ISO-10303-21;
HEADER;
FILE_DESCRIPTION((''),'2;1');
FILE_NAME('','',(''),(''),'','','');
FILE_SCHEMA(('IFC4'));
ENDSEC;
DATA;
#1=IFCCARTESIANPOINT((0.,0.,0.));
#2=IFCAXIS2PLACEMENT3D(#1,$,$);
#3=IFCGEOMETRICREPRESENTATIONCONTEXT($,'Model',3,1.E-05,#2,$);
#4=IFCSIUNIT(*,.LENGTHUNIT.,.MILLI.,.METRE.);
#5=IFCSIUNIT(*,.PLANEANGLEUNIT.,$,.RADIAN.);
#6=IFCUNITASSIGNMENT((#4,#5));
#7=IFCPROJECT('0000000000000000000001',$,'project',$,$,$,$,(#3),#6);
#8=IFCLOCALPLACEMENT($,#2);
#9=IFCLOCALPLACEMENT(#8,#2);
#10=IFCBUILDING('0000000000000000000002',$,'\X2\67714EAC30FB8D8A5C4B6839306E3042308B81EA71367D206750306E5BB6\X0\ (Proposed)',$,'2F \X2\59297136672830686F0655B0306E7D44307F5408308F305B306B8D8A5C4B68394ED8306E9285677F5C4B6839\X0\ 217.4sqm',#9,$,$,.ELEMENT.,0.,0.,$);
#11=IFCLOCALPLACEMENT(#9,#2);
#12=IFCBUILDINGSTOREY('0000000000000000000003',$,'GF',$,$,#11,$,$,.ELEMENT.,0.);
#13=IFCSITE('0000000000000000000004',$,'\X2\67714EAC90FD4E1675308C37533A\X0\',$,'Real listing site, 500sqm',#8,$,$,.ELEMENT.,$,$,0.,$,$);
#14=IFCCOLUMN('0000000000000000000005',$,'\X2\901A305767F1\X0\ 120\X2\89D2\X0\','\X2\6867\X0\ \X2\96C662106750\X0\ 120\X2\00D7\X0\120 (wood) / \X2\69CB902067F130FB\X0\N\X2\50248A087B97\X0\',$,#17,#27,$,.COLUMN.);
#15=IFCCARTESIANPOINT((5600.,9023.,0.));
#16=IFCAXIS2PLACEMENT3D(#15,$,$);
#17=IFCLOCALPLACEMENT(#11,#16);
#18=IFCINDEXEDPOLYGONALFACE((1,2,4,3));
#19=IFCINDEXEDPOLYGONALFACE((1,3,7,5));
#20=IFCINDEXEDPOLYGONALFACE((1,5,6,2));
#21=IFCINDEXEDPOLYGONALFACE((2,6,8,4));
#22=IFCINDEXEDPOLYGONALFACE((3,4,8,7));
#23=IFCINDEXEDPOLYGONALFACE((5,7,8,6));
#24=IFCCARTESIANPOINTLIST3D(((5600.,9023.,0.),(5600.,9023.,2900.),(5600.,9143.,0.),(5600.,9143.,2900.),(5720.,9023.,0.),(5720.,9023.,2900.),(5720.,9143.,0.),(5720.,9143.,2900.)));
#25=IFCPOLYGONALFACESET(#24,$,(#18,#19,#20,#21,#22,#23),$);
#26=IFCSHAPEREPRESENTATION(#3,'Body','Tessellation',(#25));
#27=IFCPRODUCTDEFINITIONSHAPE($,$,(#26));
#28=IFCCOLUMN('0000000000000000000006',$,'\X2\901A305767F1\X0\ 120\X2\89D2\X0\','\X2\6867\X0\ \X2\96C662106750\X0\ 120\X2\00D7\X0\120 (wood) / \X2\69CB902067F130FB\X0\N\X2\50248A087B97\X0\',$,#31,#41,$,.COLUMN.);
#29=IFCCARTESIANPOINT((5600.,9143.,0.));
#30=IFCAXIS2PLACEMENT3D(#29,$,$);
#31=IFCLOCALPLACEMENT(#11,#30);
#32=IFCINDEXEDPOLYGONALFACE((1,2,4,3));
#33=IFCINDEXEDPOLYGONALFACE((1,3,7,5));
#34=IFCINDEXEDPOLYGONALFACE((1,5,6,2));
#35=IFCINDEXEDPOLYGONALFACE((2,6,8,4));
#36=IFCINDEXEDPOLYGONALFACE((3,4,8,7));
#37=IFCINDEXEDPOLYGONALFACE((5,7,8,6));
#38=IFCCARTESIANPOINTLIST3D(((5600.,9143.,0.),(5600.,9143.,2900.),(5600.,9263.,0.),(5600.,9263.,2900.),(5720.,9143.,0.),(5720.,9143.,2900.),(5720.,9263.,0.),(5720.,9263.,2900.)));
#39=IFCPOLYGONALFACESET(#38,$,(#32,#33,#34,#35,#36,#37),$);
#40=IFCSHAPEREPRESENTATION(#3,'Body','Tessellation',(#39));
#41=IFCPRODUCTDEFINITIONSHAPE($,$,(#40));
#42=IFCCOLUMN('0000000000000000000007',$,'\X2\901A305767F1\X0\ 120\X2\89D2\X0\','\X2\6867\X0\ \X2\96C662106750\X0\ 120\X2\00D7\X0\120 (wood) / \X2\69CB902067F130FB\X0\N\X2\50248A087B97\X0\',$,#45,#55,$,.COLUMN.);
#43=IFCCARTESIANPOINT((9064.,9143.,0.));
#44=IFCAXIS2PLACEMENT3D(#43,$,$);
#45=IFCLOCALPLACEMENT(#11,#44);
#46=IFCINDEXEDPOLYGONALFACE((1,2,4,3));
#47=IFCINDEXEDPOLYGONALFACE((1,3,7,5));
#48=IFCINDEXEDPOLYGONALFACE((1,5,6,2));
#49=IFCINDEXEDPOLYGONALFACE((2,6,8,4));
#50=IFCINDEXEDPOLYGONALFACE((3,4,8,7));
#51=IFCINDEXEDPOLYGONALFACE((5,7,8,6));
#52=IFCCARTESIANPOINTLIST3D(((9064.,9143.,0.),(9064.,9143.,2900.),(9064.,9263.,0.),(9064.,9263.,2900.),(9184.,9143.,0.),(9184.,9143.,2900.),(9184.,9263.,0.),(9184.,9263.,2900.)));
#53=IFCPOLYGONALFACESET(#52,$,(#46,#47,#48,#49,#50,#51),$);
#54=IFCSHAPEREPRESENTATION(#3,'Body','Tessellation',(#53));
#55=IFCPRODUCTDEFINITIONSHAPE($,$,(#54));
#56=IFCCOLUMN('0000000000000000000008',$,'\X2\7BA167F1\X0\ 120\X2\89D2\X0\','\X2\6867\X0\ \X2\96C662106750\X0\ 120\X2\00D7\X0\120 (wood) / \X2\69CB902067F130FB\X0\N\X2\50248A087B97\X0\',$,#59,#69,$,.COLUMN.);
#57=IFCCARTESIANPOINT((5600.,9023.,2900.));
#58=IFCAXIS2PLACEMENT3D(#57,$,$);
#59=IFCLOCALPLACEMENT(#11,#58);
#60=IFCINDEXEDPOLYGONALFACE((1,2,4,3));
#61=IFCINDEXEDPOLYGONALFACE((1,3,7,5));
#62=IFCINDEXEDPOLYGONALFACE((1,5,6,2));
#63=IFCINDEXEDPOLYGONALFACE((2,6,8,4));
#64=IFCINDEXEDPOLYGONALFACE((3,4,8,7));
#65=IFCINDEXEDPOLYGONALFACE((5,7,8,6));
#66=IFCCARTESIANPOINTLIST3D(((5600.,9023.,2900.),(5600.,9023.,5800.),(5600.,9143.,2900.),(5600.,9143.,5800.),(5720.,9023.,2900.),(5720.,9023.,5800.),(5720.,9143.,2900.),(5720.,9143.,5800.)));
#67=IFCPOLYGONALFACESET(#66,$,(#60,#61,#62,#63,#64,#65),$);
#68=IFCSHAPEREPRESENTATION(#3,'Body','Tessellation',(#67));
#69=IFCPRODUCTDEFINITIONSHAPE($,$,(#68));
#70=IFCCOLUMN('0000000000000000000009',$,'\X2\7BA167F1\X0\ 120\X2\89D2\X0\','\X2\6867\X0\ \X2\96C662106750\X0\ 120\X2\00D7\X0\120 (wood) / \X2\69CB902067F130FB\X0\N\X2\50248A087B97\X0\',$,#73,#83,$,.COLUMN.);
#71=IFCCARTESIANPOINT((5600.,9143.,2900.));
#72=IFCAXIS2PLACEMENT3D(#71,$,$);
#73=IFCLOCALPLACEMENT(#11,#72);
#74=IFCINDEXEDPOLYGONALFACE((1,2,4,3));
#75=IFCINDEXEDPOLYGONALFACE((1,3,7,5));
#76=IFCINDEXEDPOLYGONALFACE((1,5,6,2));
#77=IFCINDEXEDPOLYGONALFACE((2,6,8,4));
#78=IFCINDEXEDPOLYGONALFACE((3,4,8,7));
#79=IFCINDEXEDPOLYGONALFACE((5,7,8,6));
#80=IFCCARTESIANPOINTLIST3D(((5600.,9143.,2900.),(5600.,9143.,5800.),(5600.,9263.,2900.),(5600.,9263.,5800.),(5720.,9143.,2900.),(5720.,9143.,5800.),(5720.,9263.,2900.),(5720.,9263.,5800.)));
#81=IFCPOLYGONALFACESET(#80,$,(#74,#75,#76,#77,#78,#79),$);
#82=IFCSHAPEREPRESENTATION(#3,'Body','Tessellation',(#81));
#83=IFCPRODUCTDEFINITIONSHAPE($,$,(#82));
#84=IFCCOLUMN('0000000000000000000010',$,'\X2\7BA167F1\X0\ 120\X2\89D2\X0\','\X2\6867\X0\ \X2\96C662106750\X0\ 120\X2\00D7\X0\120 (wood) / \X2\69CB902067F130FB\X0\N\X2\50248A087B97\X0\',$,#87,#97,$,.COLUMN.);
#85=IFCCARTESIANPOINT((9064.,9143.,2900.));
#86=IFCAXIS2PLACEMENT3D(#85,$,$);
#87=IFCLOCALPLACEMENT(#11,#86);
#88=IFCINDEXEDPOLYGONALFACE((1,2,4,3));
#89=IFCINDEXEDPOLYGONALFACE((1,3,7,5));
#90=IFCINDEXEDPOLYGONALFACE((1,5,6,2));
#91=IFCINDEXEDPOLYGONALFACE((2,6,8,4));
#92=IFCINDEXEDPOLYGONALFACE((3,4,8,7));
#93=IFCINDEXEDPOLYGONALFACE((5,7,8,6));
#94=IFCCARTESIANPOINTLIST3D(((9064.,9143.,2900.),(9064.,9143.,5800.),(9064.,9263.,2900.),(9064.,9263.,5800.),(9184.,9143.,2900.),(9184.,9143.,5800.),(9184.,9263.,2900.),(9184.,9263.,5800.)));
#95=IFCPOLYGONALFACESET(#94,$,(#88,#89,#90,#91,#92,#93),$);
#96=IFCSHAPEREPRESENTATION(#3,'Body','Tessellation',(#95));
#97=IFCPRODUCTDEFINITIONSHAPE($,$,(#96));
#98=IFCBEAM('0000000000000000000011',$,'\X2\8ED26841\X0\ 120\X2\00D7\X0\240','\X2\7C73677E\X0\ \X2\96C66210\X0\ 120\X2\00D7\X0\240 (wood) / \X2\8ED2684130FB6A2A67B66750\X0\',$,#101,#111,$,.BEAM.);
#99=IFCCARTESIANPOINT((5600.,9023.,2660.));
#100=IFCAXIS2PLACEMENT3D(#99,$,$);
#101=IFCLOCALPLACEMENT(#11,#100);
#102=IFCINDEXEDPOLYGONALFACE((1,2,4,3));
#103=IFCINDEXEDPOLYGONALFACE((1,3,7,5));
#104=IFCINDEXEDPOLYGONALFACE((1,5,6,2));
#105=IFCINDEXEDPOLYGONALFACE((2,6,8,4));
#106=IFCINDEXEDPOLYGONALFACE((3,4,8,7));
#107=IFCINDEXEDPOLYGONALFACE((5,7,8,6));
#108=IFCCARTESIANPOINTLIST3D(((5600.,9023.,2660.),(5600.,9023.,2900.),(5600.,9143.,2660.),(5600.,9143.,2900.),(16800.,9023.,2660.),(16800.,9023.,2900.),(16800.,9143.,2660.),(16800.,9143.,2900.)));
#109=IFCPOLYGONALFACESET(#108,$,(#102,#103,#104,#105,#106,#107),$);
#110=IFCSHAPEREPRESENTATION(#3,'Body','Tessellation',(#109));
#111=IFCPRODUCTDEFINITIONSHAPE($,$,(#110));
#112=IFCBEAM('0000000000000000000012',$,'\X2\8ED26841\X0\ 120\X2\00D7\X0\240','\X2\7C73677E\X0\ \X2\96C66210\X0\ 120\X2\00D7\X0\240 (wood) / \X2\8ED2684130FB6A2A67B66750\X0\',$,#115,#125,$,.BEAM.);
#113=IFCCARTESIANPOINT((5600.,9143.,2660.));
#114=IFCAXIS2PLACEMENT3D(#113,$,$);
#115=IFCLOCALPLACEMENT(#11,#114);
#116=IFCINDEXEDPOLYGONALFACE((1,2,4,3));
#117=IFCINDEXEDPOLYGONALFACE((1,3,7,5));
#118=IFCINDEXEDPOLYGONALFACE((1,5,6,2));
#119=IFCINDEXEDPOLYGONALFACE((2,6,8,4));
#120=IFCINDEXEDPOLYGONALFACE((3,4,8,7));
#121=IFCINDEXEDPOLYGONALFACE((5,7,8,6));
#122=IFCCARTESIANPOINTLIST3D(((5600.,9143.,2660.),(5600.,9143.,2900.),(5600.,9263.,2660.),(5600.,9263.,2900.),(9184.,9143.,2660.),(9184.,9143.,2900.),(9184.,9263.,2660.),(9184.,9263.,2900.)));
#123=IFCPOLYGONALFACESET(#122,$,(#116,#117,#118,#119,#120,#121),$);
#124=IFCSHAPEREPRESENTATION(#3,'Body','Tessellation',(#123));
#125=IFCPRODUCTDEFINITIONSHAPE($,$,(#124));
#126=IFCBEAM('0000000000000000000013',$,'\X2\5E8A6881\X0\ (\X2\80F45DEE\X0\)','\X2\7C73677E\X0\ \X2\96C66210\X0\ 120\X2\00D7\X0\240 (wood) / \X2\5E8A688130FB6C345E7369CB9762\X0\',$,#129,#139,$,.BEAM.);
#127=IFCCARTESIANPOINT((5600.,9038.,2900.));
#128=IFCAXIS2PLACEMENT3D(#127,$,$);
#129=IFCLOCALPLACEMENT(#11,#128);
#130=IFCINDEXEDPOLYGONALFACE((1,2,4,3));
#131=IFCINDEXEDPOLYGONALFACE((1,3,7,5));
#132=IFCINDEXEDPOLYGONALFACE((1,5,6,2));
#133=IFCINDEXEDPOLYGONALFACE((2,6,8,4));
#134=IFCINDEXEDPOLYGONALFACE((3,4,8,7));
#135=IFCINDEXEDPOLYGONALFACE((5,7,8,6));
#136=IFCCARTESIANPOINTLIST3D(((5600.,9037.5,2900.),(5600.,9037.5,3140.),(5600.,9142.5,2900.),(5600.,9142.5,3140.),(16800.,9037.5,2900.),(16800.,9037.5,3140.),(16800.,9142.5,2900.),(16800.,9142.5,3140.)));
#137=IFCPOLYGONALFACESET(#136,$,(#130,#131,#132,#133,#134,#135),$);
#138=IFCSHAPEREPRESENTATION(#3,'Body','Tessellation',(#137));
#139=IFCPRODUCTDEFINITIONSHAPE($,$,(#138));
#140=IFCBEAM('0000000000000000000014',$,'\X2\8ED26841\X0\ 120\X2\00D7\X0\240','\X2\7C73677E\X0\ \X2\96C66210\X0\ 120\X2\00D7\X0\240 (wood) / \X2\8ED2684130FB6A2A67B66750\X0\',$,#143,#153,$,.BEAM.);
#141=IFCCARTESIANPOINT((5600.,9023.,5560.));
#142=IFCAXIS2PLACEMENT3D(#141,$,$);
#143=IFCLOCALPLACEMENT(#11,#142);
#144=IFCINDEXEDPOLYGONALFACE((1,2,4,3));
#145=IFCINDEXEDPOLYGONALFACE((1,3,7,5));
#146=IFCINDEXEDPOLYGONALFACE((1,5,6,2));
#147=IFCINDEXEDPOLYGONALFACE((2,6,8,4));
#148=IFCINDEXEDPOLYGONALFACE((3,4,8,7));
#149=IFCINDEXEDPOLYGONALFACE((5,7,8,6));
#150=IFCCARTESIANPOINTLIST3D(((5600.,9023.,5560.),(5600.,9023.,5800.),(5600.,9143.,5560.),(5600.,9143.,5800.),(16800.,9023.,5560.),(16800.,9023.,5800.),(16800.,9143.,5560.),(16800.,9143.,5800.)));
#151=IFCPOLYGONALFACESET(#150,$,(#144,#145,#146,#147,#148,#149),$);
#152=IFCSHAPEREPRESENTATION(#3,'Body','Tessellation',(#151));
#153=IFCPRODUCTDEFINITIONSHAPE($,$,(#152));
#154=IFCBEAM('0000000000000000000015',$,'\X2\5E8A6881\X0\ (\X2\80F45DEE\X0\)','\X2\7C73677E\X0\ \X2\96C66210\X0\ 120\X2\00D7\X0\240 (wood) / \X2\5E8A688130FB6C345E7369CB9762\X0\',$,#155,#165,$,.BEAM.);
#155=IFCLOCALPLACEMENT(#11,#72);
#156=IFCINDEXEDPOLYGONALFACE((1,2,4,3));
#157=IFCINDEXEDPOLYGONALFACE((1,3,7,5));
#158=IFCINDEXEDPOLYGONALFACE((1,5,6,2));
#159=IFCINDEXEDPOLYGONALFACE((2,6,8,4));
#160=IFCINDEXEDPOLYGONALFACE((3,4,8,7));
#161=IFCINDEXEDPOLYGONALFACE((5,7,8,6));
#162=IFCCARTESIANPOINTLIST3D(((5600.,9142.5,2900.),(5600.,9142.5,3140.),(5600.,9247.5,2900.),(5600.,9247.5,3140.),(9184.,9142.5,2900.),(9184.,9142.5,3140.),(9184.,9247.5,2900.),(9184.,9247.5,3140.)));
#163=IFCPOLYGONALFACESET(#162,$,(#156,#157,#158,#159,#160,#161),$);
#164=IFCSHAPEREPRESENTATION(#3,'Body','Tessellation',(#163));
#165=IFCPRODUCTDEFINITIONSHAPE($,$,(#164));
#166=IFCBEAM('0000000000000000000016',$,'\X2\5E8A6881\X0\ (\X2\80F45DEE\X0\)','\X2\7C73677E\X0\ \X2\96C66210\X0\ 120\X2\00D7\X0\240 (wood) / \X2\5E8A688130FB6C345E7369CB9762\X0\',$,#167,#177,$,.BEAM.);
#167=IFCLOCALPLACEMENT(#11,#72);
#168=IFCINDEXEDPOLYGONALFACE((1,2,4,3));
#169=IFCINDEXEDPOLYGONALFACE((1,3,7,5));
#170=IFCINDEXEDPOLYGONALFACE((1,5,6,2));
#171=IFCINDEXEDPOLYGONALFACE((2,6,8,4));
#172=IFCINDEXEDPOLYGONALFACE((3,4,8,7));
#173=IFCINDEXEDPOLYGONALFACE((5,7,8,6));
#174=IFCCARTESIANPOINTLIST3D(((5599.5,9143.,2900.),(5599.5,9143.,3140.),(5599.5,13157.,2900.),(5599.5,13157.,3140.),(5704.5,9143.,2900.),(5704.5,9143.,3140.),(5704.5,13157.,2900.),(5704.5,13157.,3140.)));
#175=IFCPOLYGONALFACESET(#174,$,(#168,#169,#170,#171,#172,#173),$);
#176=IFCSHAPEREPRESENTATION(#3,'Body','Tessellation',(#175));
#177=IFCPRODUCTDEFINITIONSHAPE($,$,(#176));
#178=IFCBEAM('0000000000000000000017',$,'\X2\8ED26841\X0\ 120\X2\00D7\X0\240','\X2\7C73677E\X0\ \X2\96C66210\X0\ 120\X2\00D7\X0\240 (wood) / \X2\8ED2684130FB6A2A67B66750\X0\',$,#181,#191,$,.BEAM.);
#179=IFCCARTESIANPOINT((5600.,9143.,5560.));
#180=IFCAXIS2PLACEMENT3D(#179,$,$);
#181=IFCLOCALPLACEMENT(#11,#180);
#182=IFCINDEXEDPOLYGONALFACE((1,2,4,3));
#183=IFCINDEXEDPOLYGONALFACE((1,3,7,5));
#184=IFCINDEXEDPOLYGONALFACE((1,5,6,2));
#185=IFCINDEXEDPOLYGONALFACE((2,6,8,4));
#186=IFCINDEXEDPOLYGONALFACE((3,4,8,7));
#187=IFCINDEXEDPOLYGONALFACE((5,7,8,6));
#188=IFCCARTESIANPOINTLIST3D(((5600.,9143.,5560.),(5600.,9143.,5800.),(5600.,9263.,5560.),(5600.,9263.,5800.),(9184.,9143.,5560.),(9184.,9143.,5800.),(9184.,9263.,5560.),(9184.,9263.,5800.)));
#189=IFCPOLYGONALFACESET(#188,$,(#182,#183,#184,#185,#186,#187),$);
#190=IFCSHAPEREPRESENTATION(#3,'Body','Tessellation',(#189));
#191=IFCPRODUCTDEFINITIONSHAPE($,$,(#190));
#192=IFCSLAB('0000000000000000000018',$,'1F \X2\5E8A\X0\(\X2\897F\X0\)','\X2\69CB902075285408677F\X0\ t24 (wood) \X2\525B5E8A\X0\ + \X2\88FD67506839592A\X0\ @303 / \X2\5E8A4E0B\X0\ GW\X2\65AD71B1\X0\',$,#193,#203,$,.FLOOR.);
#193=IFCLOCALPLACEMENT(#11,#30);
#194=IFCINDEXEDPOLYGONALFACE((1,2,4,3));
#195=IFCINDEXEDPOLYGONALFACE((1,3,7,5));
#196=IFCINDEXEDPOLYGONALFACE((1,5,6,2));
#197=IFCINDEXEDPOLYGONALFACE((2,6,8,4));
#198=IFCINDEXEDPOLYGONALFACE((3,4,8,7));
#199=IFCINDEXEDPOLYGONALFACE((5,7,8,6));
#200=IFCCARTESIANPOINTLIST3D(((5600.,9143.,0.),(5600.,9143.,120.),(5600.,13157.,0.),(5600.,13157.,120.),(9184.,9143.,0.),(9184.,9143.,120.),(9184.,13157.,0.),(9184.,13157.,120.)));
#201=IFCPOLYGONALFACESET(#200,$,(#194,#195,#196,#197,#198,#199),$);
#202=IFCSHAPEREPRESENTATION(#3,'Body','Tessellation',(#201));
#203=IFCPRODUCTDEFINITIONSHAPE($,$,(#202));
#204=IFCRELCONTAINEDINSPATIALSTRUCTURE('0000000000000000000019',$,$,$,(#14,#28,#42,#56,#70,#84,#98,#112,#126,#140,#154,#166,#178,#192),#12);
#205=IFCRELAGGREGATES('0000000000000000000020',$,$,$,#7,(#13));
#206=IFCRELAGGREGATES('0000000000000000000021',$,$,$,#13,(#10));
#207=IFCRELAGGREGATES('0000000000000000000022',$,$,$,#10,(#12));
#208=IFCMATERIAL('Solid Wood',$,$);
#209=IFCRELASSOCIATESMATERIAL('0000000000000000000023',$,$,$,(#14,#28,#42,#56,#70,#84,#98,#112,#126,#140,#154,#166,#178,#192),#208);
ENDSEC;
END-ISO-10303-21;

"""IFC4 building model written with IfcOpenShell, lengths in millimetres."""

from ifc_helpers import new_model, si_unit, frame, frame_2d, origin, place, context, project, spatial, rectangle, extrude, material, element, save


model = new_model("IFC4")

# Units and contexts
model_context = context("Model", 3, precision=1e-05, world=origin())
ifc_project = project(units=[si_unit("LENGTHUNIT", "METRE", prefix="MILLI"), si_unit("PLANEANGLEUNIT", "RADIAN")], contexts=[model_context])

# Site, building, storey
site_placement = place(None, origin())
site = spatial("IfcSite", under=ifc_project, at=site_placement, Name="東京都世田谷区", ObjectType="Real listing site, 500sqm", CompositionType="ELEMENT", RefElevation=0.0)
building_placement = place(site_placement, origin())
building = spatial("IfcBuilding", under=site, at=building_placement, Name="東京・越屋根のある自然素材の家 (Proposed)", ObjectType="2F 天然木と漆喰の組み合わせに越屋根付の銅板屋根 217.4sqm", CompositionType="ELEMENT", ElevationOfRefHeight=0.0, ElevationOfTerrain=0.0)
storey_placement = place(building_placement, origin())
storey = spatial("IfcBuildingStorey", under=building, at=storey_placement, Name="GF", CompositionType="ELEMENT", Elevation=0.0)

# Columns
ifc_material_1 = material(Name="Solid Wood")
column_1_placement = place(storey_placement, frame((5600.0, 9023.0, 0.0)))
element("IfcColumn", 1, at=column_1_placement, inside=storey, material=ifc_material_1, Name="通し柱 120角", Description="桧 集成材 120×120 (wood) / 構造柱・N値計算", PredefinedType="COLUMN", context=model_context, shape_type="SweptSolid", body=[
    extrude(rectangle(XDim=120.0, YDim=120.0, at=frame_2d((60.0, 60.0))), frame((5600.0, 9023.0, 0.0)), (0.0, 0.0, 1.0), 2900.0),
])
column_2_placement = place(storey_placement, frame((5600.0, 9143.0, 0.0)))
element("IfcColumn", 2, at=column_2_placement, inside=storey, material=ifc_material_1, Name="通し柱 120角", Description="桧 集成材 120×120 (wood) / 構造柱・N値計算", PredefinedType="COLUMN", context=model_context, shape_type="SweptSolid", body=[
    extrude(rectangle(XDim=120.0, YDim=120.0, at=frame_2d((60.0, 60.0))), frame((5600.0, 9143.0, 0.0)), (0.0, 0.0, 1.0), 2900.0),
])
column_3_placement = place(storey_placement, frame((9064.0, 9143.0, 0.0)))
element("IfcColumn", 3, at=column_3_placement, inside=storey, material=ifc_material_1, Name="通し柱 120角", Description="桧 集成材 120×120 (wood) / 構造柱・N値計算", PredefinedType="COLUMN", context=model_context, shape_type="SweptSolid", body=[
    extrude(rectangle(XDim=120.0, YDim=120.0, at=frame_2d((60.0, 60.0))), frame((9064.0, 9143.0, 0.0)), (0.0, 0.0, 1.0), 2900.0),
])
column_4_placement = place(storey_placement, frame((5600.0, 9023.0, 2900.0)))
element("IfcColumn", 4, at=column_4_placement, inside=storey, material=ifc_material_1, Name="管柱 120角", Description="桧 集成材 120×120 (wood) / 構造柱・N値計算", PredefinedType="COLUMN", context=model_context, shape_type="SweptSolid", body=[
    extrude(rectangle(XDim=120.0, YDim=120.0, at=frame_2d((60.0, 60.0))), frame((5600.0, 9023.0, 2900.0)), (0.0, 0.0, 1.0), 2900.0),
])
column_5_placement = place(storey_placement, frame((5600.0, 9143.0, 2900.0)))
element("IfcColumn", 5, at=column_5_placement, inside=storey, material=ifc_material_1, Name="管柱 120角", Description="桧 集成材 120×120 (wood) / 構造柱・N値計算", PredefinedType="COLUMN", context=model_context, shape_type="SweptSolid", body=[
    extrude(rectangle(XDim=120.0, YDim=120.0, at=frame_2d((60.0, 60.0))), frame((5600.0, 9143.0, 2900.0)), (0.0, 0.0, 1.0), 2900.0),
])
column_6_placement = place(storey_placement, frame((9064.0, 9143.0, 2900.0)))
element("IfcColumn", 6, at=column_6_placement, inside=storey, material=ifc_material_1, Name="管柱 120角", Description="桧 集成材 120×120 (wood) / 構造柱・N値計算", PredefinedType="COLUMN", context=model_context, shape_type="SweptSolid", body=[
    extrude(rectangle(XDim=120.0, YDim=120.0, at=frame_2d((60.0, 60.0))), frame((9064.0, 9143.0, 2900.0)), (0.0, 0.0, 1.0), 2900.0),
])

# Beams
beam_1_placement = place(storey_placement, frame((5600.0, 9023.0, 2660.0)))
element("IfcBeam", 7, at=beam_1_placement, inside=storey, material=ifc_material_1, Name="軒桁 120×240", Description="米松 集成 120×240 (wood) / 軒桁・横架材", PredefinedType="BEAM", context=model_context, shape_type="SweptSolid", body=[
    extrude(rectangle(XDim=11200.0, YDim=120.0, at=frame_2d((5600.0, 60.0))), frame((5600.0, 9023.0, 2660.0)), (0.0, 0.0, 1.0), 240.0),
])
beam_2_placement = place(storey_placement, frame((5600.0, 9143.0, 2660.0)))
element("IfcBeam", 8, at=beam_2_placement, inside=storey, material=ifc_material_1, Name="軒桁 120×240", Description="米松 集成 120×240 (wood) / 軒桁・横架材", PredefinedType="BEAM", context=model_context, shape_type="SweptSolid", body=[
    extrude(rectangle(XDim=3584.0, YDim=120.0, at=frame_2d((1792.0, 60.0))), frame((5600.0, 9143.0, 2660.0)), (0.0, 0.0, 1.0), 240.0),
])
beam_3_placement = place(storey_placement, frame((5600.0, 9038.0, 2900.0)))
element("IfcBeam", 9, at=beam_3_placement, inside=storey, material=ifc_material_1, Name="床梁 (胴差)", Description="米松 集成 120×240 (wood) / 床梁・水平構面", PredefinedType="BEAM", context=model_context, shape_type="SweptSolid", body=[
    extrude(rectangle(XDim=11200.0, YDim=105.0, at=frame_2d((5600.0, 52.0))), frame((5600.0, 9038.0, 2900.0)), (0.0, 0.0, 1.0), 240.0),
])
beam_4_placement = place(storey_placement, frame((5600.0, 9023.0, 5560.0)))
element("IfcBeam", 10, at=beam_4_placement, inside=storey, material=ifc_material_1, Name="軒桁 120×240", Description="米松 集成 120×240 (wood) / 軒桁・横架材", PredefinedType="BEAM", context=model_context, shape_type="SweptSolid", body=[
    extrude(rectangle(XDim=11200.0, YDim=120.0, at=frame_2d((5600.0, 60.0))), frame((5600.0, 9023.0, 5560.0)), (0.0, 0.0, 1.0), 240.0),
])
beam_5_placement = place(storey_placement, frame((5600.0, 9143.0, 2900.0)))
element("IfcBeam", 11, at=beam_5_placement, inside=storey, material=ifc_material_1, Name="床梁 (胴差)", Description="米松 集成 120×240 (wood) / 床梁・水平構面", PredefinedType="BEAM", context=model_context, shape_type="SweptSolid", body=[
    extrude(rectangle(XDim=3584.0, YDim=105.0, at=frame_2d((1792.0, 52.0))), frame((5600.0, 9143.0, 2900.0)), (0.0, 0.0, 1.0), 240.0),
])
beam_6_placement = place(storey_placement, frame((5600.0, 9143.0, 2900.0)))
element("IfcBeam", 12, at=beam_6_placement, inside=storey, material=ifc_material_1, Name="床梁 (胴差)", Description="米松 集成 120×240 (wood) / 床梁・水平構面", PredefinedType="BEAM", context=model_context, shape_type="SweptSolid", body=[
    extrude(rectangle(XDim=105.0, YDim=4014.0, at=frame_2d((52.0, 2007.0))), frame((5600.0, 9143.0, 2900.0)), (0.0, 0.0, 1.0), 240.0),
])
beam_7_placement = place(storey_placement, frame((5600.0, 9143.0, 5560.0)))
element("IfcBeam", 13, at=beam_7_placement, inside=storey, material=ifc_material_1, Name="軒桁 120×240", Description="米松 集成 120×240 (wood) / 軒桁・横架材", PredefinedType="BEAM", context=model_context, shape_type="SweptSolid", body=[
    extrude(rectangle(XDim=3584.0, YDim=120.0, at=frame_2d((1792.0, 60.0))), frame((5600.0, 9143.0, 5560.0)), (0.0, 0.0, 1.0), 240.0),
])

# Slab
slab_1_placement = place(storey_placement, frame((5600.0, 9143.0, 0.0)))
element("IfcSlab", 14, at=slab_1_placement, inside=storey, material=ifc_material_1, Name="1F 床(西)", Description="構造用合板 t24 (wood) 剛床 + 製材根太 @303 / 床下 GW断熱", PredefinedType="FLOOR", context=model_context, shape_type="SweptSolid", body=[
    extrude(rectangle(XDim=3584.0, YDim=4014.0, at=frame_2d((1792.0, 2007.0))), frame((5600.0, 9143.0, 0.0)), (0.0, 0.0, 1.0), 120.0),
])

save(model, "model.ifc")
